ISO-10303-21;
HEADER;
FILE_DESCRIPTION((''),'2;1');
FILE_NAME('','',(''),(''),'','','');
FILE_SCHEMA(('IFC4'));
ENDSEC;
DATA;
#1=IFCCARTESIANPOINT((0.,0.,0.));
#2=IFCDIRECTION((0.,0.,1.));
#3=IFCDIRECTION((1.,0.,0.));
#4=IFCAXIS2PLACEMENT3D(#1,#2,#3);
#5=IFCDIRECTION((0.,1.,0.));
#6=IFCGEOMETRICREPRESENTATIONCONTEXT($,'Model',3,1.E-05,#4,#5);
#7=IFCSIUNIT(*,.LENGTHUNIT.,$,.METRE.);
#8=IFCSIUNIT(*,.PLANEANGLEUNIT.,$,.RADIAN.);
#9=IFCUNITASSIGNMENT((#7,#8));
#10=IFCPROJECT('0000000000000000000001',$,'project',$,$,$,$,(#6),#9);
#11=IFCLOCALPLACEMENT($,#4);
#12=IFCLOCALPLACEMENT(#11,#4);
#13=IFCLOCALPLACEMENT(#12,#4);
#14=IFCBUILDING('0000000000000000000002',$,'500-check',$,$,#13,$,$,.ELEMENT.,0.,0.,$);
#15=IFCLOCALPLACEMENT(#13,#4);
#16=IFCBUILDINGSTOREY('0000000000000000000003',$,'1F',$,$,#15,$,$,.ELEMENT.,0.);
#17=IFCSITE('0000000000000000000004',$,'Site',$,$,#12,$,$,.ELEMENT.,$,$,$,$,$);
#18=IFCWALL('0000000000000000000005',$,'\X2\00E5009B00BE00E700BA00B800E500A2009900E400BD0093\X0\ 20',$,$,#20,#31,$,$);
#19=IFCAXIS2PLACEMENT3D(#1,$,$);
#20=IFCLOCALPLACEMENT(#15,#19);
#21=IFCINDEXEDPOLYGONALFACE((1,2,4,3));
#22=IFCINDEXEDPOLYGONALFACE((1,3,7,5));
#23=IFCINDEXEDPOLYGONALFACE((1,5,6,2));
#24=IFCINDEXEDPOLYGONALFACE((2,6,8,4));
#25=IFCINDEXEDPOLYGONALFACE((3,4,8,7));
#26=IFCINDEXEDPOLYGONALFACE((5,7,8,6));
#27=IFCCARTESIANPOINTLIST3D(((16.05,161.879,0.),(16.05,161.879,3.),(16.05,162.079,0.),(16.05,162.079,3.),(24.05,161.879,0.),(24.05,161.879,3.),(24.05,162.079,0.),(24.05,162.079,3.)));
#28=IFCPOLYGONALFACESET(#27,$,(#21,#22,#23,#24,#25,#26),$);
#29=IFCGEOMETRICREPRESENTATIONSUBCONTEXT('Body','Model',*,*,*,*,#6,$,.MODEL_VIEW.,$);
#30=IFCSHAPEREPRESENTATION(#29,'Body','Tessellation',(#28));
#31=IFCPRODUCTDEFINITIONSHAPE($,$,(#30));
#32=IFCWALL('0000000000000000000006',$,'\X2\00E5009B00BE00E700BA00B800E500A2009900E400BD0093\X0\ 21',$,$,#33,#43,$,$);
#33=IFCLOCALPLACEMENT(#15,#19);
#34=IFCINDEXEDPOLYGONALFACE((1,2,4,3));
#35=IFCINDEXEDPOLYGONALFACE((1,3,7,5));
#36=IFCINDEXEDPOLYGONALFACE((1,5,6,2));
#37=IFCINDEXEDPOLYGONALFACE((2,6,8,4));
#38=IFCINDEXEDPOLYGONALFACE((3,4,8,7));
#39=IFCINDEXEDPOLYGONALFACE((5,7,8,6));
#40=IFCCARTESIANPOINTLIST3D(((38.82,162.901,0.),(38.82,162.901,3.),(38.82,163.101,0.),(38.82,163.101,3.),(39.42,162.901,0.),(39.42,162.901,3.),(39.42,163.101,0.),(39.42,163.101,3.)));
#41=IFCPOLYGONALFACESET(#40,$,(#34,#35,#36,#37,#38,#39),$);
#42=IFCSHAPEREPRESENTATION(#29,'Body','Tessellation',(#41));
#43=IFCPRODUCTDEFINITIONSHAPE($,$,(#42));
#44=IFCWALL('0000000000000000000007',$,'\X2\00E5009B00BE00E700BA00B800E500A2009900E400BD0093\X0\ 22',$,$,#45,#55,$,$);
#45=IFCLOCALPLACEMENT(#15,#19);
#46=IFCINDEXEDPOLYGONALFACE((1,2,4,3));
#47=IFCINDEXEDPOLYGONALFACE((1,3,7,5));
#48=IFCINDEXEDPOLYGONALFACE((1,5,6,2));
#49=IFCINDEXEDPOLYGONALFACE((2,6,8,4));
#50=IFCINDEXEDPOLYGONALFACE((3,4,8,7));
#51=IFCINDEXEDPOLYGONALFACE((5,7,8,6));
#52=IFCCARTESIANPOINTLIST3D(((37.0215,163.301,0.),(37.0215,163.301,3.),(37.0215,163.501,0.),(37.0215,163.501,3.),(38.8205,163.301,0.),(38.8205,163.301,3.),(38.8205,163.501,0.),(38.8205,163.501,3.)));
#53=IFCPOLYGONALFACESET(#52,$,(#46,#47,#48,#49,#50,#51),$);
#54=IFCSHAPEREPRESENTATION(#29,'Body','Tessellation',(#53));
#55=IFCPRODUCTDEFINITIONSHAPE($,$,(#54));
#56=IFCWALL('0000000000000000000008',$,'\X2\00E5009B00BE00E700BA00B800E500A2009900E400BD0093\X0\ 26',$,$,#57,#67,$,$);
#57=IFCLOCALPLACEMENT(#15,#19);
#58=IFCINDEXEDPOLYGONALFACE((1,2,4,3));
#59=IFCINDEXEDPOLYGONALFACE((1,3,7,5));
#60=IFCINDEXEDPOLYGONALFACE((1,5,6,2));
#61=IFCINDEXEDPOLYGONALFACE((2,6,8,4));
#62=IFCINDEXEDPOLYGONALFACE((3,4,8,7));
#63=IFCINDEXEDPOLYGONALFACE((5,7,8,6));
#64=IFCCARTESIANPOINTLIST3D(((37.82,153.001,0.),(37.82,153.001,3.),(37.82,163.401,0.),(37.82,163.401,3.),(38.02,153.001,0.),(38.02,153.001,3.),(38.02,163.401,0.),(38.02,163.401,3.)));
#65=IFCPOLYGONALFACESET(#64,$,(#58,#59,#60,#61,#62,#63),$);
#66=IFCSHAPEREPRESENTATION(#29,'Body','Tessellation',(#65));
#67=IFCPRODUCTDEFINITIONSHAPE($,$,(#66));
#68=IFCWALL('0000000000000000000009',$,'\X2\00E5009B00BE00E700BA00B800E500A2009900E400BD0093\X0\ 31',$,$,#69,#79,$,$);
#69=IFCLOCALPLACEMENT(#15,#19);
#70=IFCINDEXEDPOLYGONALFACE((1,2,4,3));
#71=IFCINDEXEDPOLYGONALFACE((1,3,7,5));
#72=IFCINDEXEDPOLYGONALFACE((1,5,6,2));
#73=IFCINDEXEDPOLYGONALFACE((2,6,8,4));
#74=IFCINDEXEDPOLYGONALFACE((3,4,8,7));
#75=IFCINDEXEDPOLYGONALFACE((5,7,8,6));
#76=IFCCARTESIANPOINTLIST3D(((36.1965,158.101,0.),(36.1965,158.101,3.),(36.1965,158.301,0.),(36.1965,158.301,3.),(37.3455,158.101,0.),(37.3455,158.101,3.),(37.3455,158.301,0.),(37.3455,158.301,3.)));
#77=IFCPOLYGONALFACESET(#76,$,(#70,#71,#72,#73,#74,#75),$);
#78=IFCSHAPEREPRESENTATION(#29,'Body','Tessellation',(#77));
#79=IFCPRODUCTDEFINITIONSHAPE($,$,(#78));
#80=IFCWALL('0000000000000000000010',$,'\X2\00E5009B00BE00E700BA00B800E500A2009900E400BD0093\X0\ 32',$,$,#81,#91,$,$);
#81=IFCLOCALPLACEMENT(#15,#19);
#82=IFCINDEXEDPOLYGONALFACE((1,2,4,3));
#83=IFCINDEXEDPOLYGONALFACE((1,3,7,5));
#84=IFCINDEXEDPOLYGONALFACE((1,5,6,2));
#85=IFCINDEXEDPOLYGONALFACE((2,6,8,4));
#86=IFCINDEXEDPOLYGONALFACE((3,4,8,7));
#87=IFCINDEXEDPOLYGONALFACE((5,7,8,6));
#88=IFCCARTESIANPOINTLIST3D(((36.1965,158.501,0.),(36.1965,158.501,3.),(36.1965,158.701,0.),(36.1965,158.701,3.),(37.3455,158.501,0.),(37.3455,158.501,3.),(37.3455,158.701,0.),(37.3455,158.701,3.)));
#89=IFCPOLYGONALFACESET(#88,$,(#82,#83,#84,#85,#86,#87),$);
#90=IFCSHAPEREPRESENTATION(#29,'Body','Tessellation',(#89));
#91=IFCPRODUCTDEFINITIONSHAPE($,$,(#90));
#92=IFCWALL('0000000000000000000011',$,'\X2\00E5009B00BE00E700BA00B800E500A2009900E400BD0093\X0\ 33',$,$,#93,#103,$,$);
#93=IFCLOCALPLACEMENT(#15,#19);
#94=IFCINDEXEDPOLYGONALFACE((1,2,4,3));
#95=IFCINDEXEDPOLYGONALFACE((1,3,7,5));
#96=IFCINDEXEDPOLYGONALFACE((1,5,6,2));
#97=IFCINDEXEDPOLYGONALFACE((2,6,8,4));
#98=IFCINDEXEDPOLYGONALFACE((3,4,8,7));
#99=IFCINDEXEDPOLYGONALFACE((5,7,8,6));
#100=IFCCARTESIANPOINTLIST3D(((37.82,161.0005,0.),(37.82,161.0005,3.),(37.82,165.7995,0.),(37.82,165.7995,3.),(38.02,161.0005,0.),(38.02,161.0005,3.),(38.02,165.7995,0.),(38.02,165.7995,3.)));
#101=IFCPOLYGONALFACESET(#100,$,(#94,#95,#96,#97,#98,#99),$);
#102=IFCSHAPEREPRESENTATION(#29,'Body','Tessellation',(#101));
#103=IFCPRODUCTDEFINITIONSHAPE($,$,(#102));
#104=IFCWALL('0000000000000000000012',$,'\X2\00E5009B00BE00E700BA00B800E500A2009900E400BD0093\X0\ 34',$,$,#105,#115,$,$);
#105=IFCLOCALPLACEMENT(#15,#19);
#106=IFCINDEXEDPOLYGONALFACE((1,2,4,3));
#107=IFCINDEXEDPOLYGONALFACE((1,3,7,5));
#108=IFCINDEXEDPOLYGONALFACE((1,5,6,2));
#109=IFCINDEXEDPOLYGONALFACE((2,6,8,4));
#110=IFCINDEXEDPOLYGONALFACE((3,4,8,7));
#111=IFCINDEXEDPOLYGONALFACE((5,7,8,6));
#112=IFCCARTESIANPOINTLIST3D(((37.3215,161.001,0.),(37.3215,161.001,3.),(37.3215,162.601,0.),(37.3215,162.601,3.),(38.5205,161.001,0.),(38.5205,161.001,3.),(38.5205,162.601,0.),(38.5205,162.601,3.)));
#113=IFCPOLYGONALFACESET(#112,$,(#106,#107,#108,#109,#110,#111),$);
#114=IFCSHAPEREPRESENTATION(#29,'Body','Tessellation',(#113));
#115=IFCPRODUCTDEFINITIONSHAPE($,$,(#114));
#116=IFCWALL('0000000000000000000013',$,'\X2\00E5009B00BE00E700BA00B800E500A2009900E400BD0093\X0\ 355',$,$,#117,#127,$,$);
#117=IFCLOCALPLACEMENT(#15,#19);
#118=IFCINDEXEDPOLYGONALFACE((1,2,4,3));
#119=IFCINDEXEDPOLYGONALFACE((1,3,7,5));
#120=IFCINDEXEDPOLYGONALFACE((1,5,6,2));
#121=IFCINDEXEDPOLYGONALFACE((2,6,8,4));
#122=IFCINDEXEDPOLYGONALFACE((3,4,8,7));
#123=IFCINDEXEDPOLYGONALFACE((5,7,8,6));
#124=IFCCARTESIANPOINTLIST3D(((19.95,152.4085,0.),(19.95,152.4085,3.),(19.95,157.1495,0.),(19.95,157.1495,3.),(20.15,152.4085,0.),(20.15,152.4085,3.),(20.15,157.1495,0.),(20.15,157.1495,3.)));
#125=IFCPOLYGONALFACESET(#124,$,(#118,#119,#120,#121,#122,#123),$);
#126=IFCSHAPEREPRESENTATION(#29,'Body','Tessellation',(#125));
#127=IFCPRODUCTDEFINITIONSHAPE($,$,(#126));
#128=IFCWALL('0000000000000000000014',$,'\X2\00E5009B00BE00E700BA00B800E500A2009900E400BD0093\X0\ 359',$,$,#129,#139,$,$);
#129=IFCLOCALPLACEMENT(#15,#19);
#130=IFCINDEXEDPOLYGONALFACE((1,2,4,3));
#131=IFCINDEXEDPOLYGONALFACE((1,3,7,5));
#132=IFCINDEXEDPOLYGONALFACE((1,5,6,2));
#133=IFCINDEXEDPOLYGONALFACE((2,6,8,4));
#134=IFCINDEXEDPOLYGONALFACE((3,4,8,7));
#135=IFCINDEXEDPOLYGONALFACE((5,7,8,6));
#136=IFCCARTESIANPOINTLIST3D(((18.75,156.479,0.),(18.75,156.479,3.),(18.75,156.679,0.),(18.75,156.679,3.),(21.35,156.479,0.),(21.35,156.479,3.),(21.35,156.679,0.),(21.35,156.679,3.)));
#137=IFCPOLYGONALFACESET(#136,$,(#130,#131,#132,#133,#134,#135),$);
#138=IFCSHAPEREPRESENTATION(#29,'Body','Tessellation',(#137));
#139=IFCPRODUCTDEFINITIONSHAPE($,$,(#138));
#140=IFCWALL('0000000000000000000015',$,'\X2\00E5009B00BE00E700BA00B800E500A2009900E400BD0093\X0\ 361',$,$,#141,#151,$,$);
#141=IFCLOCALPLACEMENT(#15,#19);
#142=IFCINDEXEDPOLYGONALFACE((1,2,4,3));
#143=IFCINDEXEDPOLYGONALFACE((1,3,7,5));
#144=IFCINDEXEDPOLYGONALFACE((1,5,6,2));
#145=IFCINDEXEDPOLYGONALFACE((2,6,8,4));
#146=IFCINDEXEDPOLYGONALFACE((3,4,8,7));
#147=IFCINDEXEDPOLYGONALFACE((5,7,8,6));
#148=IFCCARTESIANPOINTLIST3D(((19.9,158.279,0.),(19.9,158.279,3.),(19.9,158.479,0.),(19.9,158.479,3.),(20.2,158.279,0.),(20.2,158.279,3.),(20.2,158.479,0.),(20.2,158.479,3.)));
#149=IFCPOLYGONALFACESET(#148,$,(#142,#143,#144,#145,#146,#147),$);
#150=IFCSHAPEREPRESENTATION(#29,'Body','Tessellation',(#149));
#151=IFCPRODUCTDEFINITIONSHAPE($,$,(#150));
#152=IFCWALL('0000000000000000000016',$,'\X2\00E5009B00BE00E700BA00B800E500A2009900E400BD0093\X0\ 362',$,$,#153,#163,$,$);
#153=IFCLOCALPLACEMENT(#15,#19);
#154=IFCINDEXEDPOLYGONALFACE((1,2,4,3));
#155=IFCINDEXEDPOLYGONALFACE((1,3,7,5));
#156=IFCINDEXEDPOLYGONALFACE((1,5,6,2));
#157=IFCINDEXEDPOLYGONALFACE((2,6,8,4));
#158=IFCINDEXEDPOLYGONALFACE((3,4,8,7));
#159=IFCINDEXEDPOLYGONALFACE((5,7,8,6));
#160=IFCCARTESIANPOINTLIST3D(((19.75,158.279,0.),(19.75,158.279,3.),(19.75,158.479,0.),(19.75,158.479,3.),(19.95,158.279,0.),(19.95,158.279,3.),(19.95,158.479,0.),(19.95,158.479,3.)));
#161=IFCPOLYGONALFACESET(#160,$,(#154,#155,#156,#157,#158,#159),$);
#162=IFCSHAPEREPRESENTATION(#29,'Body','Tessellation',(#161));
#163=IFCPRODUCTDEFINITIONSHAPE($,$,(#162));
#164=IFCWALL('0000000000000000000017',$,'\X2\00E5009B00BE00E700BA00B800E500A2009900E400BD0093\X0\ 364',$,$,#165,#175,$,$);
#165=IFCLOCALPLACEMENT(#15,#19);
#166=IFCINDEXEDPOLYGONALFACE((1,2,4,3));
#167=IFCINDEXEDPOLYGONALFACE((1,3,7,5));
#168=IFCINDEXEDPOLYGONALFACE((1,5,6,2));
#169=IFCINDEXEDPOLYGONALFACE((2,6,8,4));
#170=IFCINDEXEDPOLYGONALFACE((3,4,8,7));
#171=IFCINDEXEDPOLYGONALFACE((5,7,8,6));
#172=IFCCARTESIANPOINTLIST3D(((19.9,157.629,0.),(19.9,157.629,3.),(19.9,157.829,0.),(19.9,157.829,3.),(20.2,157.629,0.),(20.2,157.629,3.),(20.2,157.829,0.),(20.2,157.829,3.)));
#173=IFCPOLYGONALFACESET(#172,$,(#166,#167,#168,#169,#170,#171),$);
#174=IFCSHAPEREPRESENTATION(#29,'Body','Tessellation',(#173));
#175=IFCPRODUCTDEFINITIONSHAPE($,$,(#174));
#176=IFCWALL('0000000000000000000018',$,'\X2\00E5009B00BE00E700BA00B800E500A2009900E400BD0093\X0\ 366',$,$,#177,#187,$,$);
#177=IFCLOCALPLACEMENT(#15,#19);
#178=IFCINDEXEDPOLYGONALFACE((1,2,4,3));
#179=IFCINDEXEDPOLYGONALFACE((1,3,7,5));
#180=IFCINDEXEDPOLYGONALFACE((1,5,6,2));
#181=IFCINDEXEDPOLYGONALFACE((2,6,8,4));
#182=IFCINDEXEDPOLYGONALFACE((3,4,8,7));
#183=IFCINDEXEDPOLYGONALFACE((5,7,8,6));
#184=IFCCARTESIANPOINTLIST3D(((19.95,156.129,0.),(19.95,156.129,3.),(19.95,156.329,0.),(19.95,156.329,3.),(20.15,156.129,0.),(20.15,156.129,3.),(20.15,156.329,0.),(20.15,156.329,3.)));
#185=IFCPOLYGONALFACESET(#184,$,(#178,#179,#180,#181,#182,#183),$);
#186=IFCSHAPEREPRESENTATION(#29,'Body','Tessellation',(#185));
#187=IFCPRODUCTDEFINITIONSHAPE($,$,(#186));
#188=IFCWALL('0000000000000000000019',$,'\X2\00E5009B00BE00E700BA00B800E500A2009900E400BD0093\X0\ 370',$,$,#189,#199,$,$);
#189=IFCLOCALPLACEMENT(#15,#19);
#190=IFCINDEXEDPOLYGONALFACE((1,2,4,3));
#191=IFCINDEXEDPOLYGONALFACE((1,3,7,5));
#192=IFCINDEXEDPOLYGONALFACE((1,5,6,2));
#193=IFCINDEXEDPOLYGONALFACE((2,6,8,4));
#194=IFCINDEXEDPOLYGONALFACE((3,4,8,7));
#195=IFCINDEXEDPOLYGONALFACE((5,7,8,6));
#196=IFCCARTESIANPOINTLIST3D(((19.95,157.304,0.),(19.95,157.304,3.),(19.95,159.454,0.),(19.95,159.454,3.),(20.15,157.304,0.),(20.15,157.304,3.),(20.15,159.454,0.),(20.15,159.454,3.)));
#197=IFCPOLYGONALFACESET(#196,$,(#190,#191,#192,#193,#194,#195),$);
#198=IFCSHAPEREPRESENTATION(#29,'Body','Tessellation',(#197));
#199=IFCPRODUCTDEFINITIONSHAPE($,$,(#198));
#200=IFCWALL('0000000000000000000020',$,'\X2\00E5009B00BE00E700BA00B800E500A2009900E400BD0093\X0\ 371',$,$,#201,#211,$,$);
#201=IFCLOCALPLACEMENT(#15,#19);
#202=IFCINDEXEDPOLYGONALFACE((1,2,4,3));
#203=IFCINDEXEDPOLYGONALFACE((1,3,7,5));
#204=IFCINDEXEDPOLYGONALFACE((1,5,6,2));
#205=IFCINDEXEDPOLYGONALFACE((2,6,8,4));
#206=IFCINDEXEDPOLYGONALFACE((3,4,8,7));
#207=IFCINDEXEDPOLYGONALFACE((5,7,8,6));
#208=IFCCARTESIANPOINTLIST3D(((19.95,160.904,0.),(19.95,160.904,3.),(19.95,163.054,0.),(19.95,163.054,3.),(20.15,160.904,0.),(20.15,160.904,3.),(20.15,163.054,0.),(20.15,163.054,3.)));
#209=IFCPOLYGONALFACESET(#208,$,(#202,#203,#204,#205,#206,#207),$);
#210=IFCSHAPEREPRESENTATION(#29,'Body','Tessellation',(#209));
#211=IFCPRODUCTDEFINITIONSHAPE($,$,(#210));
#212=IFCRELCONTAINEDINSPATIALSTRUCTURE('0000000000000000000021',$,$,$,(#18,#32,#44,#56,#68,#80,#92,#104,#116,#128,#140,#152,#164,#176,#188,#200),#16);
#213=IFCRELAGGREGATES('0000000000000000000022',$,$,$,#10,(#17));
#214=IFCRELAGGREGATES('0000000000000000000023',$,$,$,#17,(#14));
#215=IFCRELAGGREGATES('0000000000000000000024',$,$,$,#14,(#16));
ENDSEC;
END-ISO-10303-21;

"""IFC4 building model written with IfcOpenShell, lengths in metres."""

from ifc_helpers import new_model, si_unit, direction, frame, frame_2d, origin_with_axes, place, context, subcontext, project, spatial, rectangle, extrude, element, save


model = new_model("IFC4")

# Units and contexts
model_context = context("Model", 3, precision=1e-05, world=origin_with_axes(), true_north=direction((0.0, 1.0, 0.0)))
body_context = subcontext(model_context, "Body", "Model", "MODEL_VIEW")
ifc_project = project(units=[si_unit("LENGTHUNIT", "METRE"), si_unit("PLANEANGLEUNIT", "RADIAN")], contexts=[model_context])

# Site, building, storey
placement = place(None, origin_with_axes())
site_placement = place(placement, origin_with_axes())
site = spatial("IfcSite", under=ifc_project, at=site_placement, Name="Site", CompositionType="ELEMENT")
building_placement = place(site_placement, origin_with_axes())
building = spatial("IfcBuilding", under=site, at=building_placement, Name="500-check", CompositionType="ELEMENT", ElevationOfRefHeight=0.0, ElevationOfTerrain=0.0)
storey_placement = place(building_placement, origin_with_axes())
storey = spatial("IfcBuildingStorey", under=building, at=storey_placement, Name="1F", CompositionType="ELEMENT", Elevation=0.0)

# Walls
wall_1_placement = place(storey_placement, frame((20.05, 161.979, 0.0), z_axis=(0.0, 0.0, 1.0), x_axis=(-1.0, 0.0, 0.0)))
element("IfcWall", 1, at=wall_1_placement, inside=storey, Name="å\u009b¾çº¸å¢\u0099ä½\u0093 20", context=body_context, shape_type="SweptSolid", body=[
    extrude(rectangle(XDim=8.0, YDim=0.2, at=frame_2d((0.0, 0.0), x_axis=(1.0, 0.0, 0.0))), frame((0.0, 0.0, 0.0), z_axis=(0.0, 0.0, 1.0)), (0.0, 0.0, 1.0), 3.0),
])
wall_2_placement = place(storey_placement, frame((39.12, 163.001, 0.0), z_axis=(0.0, 0.0, 1.0), x_axis=(1.0, 0.0, 0.0)))
element("IfcWall", 2, at=wall_2_placement, inside=storey, Name="å\u009b¾çº¸å¢\u0099ä½\u0093 21", context=body_context, shape_type="SweptSolid", body=[
    extrude(rectangle(XDim=0.6, YDim=0.2, at=frame_2d((0.0, 0.0), x_axis=(1.0, 0.0, 0.0))), frame((0.0, 0.0, 0.0), z_axis=(0.0, 0.0, 1.0)), (0.0, 0.0, 1.0), 3.0),
])
wall_3_placement = place(storey_placement, frame((37.921, 163.401, 0.0), z_axis=(0.0, 0.0, 1.0), x_axis=(1.0, 0.0, 0.0)))
element("IfcWall", 3, at=wall_3_placement, inside=storey, Name="å\u009b¾çº¸å¢\u0099ä½\u0093 22", context=body_context, shape_type="SweptSolid", body=[
    extrude(rectangle(XDim=1.799, YDim=0.2, at=frame_2d((0.0, 0.0), x_axis=(1.0, 0.0, 0.0))), frame((0.0, 0.0, 0.0), z_axis=(0.0, 0.0, 1.0)), (0.0, 0.0, 1.0), 3.0),
])
wall_4_placement = place(storey_placement, frame((37.92, 158.201, 0.0), z_axis=(0.0, 0.0, 1.0), x_axis=(0.0, -1.0, 0.0)))
element("IfcWall", 4, at=wall_4_placement, inside=storey, Name="å\u009b¾çº¸å¢\u0099ä½\u0093 26", context=body_context, shape_type="SweptSolid", body=[
    extrude(rectangle(XDim=10.4, YDim=0.2, at=frame_2d((0.0, 0.0), x_axis=(1.0, 0.0, 0.0))), frame((0.0, 0.0, 0.0), z_axis=(0.0, 0.0, 1.0)), (0.0, 0.0, 1.0), 3.0),
])
for number, where, z_axis, x_axis, name in (
    (5, (36.771, 158.201, 0.0), (0.0, 0.0, 1.0), (1.0, 0.0, 0.0), "å\u009b¾çº¸å¢\u0099ä½\u0093 31"),
    (6, (36.771, 158.601, 0.0), (0.0, 0.0, 1.0), (1.0, 0.0, 0.0), "å\u009b¾çº¸å¢\u0099ä½\u0093 32"),
):
    element("IfcWall", number, at=place(storey_placement, frame(where, z_axis=z_axis, x_axis=x_axis)), inside=storey, Name=name, context=body_context, shape_type="SweptSolid", body=[
        extrude(rectangle(XDim=1.149, YDim=0.2, at=frame_2d((0.0, 0.0), x_axis=(1.0, 0.0, 0.0))), frame((0.0, 0.0, 0.0), z_axis=(0.0, 0.0, 1.0)), (0.0, 0.0, 1.0), 3.0),
    ])
wall_5_placement = place(storey_placement, frame((37.92, 163.4, 0.0), z_axis=(0.0, 0.0, 1.0), x_axis=(0.0, -1.0, 0.0)))
element("IfcWall", 7, at=wall_5_placement, inside=storey, Name="å\u009b¾çº¸å¢\u0099ä½\u0093 33", context=body_context, shape_type="SweptSolid", body=[
    extrude(rectangle(XDim=4.799, YDim=0.2, at=frame_2d((0.0, 0.0), x_axis=(1.0, 0.0, 0.0))), frame((0.0, 0.0, 0.0), z_axis=(0.0, 0.0, 1.0)), (0.0, 0.0, 1.0), 3.0),
])
wall_6_placement = place(storey_placement, frame((37.921, 161.801, 0.0), z_axis=(0.0, 0.0, 1.0), x_axis=(1.0, 0.0, 0.0)))
element("IfcWall", 8, at=wall_6_placement, inside=storey, Name="å\u009b¾çº¸å¢\u0099ä½\u0093 34", context=body_context, shape_type="SweptSolid", body=[
    extrude(rectangle(XDim=1.199, YDim=1.6, at=frame_2d((0.0, 0.0), x_axis=(1.0, 0.0, 0.0))), frame((0.0, 0.0, 0.0), z_axis=(0.0, 0.0, 1.0)), (0.0, 0.0, 1.0), 3.0),
])
wall_7_placement = place(storey_placement, frame((20.05, 154.779, 0.0), z_axis=(0.0, 0.0, 1.0), x_axis=(0.0, -1.0, 0.0)))
element("IfcWall", 9, at=wall_7_placement, inside=storey, Name="å\u009b¾çº¸å¢\u0099ä½\u0093 355", context=body_context, shape_type="SweptSolid", body=[
    extrude(rectangle(XDim=4.741, YDim=0.2, at=frame_2d((0.0, 0.0), x_axis=(1.0, 0.0, 0.0))), frame((0.0, 0.0, 0.0), z_axis=(0.0, 0.0, 1.0)), (0.0, 0.0, 1.0), 3.0),
])
wall_8_placement = place(storey_placement, frame((20.05, 156.579, 0.0), z_axis=(0.0, 0.0, 1.0), x_axis=(-1.0, 0.0, 0.0)))
element("IfcWall", 10, at=wall_8_placement, inside=storey, Name="å\u009b¾çº¸å¢\u0099ä½\u0093 359", context=body_context, shape_type="SweptSolid", body=[
    extrude(rectangle(XDim=2.6, YDim=0.2, at=frame_2d((0.0, 0.0), x_axis=(1.0, 0.0, 0.0))), frame((0.0, 0.0, 0.0), z_axis=(0.0, 0.0, 1.0)), (0.0, 0.0, 1.0), 3.0),
])
wall_9_placement = place(storey_placement, frame((20.05, 158.379, 0.0), z_axis=(0.0, 0.0, 1.0), x_axis=(-1.0, 0.0, 0.0)))
element("IfcWall", 11, at=wall_9_placement, inside=storey, Name="å\u009b¾çº¸å¢\u0099ä½\u0093 361", context=body_context, shape_type="SweptSolid", body=[
    extrude(rectangle(XDim=0.3, YDim=0.2, at=frame_2d((0.0, 0.0), x_axis=(1.0, 0.0, 0.0))), frame((0.0, 0.0, 0.0), z_axis=(0.0, 0.0, 1.0)), (0.0, 0.0, 1.0), 3.0),
])
wall_10_placement = place(storey_placement, frame((19.85, 158.379, 0.0), z_axis=(0.0, 0.0, 1.0), x_axis=(1.0, 0.0, 0.0)))
element("IfcWall", 12, at=wall_10_placement, inside=storey, Name="å\u009b¾çº¸å¢\u0099ä½\u0093 362", context=body_context, shape_type="SweptSolid", body=[
    extrude(rectangle(XDim=0.2, YDim=0.2, at=frame_2d((0.0, 0.0), x_axis=(1.0, 0.0, 0.0))), frame((0.0, 0.0, 0.0), z_axis=(0.0, 0.0, 1.0)), (0.0, 0.0, 1.0), 3.0),
])
for number, where, z_axis, x_axis, name in (
    (13, (20.05, 157.729, 0.0), (0.0, 0.0, 1.0), (-1.0, 0.0, 0.0), "å\u009b¾çº¸å¢\u0099ä½\u0093 364"),
):
    element("IfcWall", number, at=place(storey_placement, frame(where, z_axis=z_axis, x_axis=x_axis)), inside=storey, Name=name, context=body_context, shape_type="SweptSolid", body=[
        extrude(rectangle(XDim=0.3, YDim=0.2, at=frame_2d((0.0, 0.0), x_axis=(1.0, 0.0, 0.0))), frame((0.0, 0.0, 0.0), z_axis=(0.0, 0.0, 1.0)), (0.0, 0.0, 1.0), 3.0),
    ])
wall_11_placement = place(storey_placement, frame((20.05, 156.229, 0.0), z_axis=(0.0, 0.0, 1.0), x_axis=(-1.0, 0.0, 0.0)))
element("IfcWall", 14, at=wall_11_placement, inside=storey, Name="å\u009b¾çº¸å¢\u0099ä½\u0093 366", context=body_context, shape_type="SweptSolid", body=[
    extrude(rectangle(XDim=0.2, YDim=0.2, at=frame_2d((0.0, 0.0), x_axis=(1.0, 0.0, 0.0))), frame((0.0, 0.0, 0.0), z_axis=(0.0, 0.0, 1.0)), (0.0, 0.0, 1.0), 3.0),
])
for number, where, z_axis, x_axis, name in (
    (15, (20.05, 158.379, 0.0), (0.0, 0.0, 1.0), (0.0, -1.0, 0.0), "å\u009b¾çº¸å¢\u0099ä½\u0093 370"),
    (16, (20.05, 161.979, 0.0), (0.0, 0.0, 1.0), (0.0, -1.0, 0.0), "å\u009b¾çº¸å¢\u0099ä½\u0093 371"),
):
    element("IfcWall", number, at=place(storey_placement, frame(where, z_axis=z_axis, x_axis=x_axis)), inside=storey, Name=name, context=body_context, shape_type="SweptSolid", body=[
        extrude(rectangle(XDim=2.15, YDim=0.2, at=frame_2d((0.0, 0.0), x_axis=(1.0, 0.0, 0.0))), frame((0.0, 0.0, 0.0), z_axis=(0.0, 0.0, 1.0)), (0.0, 0.0, 1.0), 3.0),
    ])

save(model, "model.ifc")
